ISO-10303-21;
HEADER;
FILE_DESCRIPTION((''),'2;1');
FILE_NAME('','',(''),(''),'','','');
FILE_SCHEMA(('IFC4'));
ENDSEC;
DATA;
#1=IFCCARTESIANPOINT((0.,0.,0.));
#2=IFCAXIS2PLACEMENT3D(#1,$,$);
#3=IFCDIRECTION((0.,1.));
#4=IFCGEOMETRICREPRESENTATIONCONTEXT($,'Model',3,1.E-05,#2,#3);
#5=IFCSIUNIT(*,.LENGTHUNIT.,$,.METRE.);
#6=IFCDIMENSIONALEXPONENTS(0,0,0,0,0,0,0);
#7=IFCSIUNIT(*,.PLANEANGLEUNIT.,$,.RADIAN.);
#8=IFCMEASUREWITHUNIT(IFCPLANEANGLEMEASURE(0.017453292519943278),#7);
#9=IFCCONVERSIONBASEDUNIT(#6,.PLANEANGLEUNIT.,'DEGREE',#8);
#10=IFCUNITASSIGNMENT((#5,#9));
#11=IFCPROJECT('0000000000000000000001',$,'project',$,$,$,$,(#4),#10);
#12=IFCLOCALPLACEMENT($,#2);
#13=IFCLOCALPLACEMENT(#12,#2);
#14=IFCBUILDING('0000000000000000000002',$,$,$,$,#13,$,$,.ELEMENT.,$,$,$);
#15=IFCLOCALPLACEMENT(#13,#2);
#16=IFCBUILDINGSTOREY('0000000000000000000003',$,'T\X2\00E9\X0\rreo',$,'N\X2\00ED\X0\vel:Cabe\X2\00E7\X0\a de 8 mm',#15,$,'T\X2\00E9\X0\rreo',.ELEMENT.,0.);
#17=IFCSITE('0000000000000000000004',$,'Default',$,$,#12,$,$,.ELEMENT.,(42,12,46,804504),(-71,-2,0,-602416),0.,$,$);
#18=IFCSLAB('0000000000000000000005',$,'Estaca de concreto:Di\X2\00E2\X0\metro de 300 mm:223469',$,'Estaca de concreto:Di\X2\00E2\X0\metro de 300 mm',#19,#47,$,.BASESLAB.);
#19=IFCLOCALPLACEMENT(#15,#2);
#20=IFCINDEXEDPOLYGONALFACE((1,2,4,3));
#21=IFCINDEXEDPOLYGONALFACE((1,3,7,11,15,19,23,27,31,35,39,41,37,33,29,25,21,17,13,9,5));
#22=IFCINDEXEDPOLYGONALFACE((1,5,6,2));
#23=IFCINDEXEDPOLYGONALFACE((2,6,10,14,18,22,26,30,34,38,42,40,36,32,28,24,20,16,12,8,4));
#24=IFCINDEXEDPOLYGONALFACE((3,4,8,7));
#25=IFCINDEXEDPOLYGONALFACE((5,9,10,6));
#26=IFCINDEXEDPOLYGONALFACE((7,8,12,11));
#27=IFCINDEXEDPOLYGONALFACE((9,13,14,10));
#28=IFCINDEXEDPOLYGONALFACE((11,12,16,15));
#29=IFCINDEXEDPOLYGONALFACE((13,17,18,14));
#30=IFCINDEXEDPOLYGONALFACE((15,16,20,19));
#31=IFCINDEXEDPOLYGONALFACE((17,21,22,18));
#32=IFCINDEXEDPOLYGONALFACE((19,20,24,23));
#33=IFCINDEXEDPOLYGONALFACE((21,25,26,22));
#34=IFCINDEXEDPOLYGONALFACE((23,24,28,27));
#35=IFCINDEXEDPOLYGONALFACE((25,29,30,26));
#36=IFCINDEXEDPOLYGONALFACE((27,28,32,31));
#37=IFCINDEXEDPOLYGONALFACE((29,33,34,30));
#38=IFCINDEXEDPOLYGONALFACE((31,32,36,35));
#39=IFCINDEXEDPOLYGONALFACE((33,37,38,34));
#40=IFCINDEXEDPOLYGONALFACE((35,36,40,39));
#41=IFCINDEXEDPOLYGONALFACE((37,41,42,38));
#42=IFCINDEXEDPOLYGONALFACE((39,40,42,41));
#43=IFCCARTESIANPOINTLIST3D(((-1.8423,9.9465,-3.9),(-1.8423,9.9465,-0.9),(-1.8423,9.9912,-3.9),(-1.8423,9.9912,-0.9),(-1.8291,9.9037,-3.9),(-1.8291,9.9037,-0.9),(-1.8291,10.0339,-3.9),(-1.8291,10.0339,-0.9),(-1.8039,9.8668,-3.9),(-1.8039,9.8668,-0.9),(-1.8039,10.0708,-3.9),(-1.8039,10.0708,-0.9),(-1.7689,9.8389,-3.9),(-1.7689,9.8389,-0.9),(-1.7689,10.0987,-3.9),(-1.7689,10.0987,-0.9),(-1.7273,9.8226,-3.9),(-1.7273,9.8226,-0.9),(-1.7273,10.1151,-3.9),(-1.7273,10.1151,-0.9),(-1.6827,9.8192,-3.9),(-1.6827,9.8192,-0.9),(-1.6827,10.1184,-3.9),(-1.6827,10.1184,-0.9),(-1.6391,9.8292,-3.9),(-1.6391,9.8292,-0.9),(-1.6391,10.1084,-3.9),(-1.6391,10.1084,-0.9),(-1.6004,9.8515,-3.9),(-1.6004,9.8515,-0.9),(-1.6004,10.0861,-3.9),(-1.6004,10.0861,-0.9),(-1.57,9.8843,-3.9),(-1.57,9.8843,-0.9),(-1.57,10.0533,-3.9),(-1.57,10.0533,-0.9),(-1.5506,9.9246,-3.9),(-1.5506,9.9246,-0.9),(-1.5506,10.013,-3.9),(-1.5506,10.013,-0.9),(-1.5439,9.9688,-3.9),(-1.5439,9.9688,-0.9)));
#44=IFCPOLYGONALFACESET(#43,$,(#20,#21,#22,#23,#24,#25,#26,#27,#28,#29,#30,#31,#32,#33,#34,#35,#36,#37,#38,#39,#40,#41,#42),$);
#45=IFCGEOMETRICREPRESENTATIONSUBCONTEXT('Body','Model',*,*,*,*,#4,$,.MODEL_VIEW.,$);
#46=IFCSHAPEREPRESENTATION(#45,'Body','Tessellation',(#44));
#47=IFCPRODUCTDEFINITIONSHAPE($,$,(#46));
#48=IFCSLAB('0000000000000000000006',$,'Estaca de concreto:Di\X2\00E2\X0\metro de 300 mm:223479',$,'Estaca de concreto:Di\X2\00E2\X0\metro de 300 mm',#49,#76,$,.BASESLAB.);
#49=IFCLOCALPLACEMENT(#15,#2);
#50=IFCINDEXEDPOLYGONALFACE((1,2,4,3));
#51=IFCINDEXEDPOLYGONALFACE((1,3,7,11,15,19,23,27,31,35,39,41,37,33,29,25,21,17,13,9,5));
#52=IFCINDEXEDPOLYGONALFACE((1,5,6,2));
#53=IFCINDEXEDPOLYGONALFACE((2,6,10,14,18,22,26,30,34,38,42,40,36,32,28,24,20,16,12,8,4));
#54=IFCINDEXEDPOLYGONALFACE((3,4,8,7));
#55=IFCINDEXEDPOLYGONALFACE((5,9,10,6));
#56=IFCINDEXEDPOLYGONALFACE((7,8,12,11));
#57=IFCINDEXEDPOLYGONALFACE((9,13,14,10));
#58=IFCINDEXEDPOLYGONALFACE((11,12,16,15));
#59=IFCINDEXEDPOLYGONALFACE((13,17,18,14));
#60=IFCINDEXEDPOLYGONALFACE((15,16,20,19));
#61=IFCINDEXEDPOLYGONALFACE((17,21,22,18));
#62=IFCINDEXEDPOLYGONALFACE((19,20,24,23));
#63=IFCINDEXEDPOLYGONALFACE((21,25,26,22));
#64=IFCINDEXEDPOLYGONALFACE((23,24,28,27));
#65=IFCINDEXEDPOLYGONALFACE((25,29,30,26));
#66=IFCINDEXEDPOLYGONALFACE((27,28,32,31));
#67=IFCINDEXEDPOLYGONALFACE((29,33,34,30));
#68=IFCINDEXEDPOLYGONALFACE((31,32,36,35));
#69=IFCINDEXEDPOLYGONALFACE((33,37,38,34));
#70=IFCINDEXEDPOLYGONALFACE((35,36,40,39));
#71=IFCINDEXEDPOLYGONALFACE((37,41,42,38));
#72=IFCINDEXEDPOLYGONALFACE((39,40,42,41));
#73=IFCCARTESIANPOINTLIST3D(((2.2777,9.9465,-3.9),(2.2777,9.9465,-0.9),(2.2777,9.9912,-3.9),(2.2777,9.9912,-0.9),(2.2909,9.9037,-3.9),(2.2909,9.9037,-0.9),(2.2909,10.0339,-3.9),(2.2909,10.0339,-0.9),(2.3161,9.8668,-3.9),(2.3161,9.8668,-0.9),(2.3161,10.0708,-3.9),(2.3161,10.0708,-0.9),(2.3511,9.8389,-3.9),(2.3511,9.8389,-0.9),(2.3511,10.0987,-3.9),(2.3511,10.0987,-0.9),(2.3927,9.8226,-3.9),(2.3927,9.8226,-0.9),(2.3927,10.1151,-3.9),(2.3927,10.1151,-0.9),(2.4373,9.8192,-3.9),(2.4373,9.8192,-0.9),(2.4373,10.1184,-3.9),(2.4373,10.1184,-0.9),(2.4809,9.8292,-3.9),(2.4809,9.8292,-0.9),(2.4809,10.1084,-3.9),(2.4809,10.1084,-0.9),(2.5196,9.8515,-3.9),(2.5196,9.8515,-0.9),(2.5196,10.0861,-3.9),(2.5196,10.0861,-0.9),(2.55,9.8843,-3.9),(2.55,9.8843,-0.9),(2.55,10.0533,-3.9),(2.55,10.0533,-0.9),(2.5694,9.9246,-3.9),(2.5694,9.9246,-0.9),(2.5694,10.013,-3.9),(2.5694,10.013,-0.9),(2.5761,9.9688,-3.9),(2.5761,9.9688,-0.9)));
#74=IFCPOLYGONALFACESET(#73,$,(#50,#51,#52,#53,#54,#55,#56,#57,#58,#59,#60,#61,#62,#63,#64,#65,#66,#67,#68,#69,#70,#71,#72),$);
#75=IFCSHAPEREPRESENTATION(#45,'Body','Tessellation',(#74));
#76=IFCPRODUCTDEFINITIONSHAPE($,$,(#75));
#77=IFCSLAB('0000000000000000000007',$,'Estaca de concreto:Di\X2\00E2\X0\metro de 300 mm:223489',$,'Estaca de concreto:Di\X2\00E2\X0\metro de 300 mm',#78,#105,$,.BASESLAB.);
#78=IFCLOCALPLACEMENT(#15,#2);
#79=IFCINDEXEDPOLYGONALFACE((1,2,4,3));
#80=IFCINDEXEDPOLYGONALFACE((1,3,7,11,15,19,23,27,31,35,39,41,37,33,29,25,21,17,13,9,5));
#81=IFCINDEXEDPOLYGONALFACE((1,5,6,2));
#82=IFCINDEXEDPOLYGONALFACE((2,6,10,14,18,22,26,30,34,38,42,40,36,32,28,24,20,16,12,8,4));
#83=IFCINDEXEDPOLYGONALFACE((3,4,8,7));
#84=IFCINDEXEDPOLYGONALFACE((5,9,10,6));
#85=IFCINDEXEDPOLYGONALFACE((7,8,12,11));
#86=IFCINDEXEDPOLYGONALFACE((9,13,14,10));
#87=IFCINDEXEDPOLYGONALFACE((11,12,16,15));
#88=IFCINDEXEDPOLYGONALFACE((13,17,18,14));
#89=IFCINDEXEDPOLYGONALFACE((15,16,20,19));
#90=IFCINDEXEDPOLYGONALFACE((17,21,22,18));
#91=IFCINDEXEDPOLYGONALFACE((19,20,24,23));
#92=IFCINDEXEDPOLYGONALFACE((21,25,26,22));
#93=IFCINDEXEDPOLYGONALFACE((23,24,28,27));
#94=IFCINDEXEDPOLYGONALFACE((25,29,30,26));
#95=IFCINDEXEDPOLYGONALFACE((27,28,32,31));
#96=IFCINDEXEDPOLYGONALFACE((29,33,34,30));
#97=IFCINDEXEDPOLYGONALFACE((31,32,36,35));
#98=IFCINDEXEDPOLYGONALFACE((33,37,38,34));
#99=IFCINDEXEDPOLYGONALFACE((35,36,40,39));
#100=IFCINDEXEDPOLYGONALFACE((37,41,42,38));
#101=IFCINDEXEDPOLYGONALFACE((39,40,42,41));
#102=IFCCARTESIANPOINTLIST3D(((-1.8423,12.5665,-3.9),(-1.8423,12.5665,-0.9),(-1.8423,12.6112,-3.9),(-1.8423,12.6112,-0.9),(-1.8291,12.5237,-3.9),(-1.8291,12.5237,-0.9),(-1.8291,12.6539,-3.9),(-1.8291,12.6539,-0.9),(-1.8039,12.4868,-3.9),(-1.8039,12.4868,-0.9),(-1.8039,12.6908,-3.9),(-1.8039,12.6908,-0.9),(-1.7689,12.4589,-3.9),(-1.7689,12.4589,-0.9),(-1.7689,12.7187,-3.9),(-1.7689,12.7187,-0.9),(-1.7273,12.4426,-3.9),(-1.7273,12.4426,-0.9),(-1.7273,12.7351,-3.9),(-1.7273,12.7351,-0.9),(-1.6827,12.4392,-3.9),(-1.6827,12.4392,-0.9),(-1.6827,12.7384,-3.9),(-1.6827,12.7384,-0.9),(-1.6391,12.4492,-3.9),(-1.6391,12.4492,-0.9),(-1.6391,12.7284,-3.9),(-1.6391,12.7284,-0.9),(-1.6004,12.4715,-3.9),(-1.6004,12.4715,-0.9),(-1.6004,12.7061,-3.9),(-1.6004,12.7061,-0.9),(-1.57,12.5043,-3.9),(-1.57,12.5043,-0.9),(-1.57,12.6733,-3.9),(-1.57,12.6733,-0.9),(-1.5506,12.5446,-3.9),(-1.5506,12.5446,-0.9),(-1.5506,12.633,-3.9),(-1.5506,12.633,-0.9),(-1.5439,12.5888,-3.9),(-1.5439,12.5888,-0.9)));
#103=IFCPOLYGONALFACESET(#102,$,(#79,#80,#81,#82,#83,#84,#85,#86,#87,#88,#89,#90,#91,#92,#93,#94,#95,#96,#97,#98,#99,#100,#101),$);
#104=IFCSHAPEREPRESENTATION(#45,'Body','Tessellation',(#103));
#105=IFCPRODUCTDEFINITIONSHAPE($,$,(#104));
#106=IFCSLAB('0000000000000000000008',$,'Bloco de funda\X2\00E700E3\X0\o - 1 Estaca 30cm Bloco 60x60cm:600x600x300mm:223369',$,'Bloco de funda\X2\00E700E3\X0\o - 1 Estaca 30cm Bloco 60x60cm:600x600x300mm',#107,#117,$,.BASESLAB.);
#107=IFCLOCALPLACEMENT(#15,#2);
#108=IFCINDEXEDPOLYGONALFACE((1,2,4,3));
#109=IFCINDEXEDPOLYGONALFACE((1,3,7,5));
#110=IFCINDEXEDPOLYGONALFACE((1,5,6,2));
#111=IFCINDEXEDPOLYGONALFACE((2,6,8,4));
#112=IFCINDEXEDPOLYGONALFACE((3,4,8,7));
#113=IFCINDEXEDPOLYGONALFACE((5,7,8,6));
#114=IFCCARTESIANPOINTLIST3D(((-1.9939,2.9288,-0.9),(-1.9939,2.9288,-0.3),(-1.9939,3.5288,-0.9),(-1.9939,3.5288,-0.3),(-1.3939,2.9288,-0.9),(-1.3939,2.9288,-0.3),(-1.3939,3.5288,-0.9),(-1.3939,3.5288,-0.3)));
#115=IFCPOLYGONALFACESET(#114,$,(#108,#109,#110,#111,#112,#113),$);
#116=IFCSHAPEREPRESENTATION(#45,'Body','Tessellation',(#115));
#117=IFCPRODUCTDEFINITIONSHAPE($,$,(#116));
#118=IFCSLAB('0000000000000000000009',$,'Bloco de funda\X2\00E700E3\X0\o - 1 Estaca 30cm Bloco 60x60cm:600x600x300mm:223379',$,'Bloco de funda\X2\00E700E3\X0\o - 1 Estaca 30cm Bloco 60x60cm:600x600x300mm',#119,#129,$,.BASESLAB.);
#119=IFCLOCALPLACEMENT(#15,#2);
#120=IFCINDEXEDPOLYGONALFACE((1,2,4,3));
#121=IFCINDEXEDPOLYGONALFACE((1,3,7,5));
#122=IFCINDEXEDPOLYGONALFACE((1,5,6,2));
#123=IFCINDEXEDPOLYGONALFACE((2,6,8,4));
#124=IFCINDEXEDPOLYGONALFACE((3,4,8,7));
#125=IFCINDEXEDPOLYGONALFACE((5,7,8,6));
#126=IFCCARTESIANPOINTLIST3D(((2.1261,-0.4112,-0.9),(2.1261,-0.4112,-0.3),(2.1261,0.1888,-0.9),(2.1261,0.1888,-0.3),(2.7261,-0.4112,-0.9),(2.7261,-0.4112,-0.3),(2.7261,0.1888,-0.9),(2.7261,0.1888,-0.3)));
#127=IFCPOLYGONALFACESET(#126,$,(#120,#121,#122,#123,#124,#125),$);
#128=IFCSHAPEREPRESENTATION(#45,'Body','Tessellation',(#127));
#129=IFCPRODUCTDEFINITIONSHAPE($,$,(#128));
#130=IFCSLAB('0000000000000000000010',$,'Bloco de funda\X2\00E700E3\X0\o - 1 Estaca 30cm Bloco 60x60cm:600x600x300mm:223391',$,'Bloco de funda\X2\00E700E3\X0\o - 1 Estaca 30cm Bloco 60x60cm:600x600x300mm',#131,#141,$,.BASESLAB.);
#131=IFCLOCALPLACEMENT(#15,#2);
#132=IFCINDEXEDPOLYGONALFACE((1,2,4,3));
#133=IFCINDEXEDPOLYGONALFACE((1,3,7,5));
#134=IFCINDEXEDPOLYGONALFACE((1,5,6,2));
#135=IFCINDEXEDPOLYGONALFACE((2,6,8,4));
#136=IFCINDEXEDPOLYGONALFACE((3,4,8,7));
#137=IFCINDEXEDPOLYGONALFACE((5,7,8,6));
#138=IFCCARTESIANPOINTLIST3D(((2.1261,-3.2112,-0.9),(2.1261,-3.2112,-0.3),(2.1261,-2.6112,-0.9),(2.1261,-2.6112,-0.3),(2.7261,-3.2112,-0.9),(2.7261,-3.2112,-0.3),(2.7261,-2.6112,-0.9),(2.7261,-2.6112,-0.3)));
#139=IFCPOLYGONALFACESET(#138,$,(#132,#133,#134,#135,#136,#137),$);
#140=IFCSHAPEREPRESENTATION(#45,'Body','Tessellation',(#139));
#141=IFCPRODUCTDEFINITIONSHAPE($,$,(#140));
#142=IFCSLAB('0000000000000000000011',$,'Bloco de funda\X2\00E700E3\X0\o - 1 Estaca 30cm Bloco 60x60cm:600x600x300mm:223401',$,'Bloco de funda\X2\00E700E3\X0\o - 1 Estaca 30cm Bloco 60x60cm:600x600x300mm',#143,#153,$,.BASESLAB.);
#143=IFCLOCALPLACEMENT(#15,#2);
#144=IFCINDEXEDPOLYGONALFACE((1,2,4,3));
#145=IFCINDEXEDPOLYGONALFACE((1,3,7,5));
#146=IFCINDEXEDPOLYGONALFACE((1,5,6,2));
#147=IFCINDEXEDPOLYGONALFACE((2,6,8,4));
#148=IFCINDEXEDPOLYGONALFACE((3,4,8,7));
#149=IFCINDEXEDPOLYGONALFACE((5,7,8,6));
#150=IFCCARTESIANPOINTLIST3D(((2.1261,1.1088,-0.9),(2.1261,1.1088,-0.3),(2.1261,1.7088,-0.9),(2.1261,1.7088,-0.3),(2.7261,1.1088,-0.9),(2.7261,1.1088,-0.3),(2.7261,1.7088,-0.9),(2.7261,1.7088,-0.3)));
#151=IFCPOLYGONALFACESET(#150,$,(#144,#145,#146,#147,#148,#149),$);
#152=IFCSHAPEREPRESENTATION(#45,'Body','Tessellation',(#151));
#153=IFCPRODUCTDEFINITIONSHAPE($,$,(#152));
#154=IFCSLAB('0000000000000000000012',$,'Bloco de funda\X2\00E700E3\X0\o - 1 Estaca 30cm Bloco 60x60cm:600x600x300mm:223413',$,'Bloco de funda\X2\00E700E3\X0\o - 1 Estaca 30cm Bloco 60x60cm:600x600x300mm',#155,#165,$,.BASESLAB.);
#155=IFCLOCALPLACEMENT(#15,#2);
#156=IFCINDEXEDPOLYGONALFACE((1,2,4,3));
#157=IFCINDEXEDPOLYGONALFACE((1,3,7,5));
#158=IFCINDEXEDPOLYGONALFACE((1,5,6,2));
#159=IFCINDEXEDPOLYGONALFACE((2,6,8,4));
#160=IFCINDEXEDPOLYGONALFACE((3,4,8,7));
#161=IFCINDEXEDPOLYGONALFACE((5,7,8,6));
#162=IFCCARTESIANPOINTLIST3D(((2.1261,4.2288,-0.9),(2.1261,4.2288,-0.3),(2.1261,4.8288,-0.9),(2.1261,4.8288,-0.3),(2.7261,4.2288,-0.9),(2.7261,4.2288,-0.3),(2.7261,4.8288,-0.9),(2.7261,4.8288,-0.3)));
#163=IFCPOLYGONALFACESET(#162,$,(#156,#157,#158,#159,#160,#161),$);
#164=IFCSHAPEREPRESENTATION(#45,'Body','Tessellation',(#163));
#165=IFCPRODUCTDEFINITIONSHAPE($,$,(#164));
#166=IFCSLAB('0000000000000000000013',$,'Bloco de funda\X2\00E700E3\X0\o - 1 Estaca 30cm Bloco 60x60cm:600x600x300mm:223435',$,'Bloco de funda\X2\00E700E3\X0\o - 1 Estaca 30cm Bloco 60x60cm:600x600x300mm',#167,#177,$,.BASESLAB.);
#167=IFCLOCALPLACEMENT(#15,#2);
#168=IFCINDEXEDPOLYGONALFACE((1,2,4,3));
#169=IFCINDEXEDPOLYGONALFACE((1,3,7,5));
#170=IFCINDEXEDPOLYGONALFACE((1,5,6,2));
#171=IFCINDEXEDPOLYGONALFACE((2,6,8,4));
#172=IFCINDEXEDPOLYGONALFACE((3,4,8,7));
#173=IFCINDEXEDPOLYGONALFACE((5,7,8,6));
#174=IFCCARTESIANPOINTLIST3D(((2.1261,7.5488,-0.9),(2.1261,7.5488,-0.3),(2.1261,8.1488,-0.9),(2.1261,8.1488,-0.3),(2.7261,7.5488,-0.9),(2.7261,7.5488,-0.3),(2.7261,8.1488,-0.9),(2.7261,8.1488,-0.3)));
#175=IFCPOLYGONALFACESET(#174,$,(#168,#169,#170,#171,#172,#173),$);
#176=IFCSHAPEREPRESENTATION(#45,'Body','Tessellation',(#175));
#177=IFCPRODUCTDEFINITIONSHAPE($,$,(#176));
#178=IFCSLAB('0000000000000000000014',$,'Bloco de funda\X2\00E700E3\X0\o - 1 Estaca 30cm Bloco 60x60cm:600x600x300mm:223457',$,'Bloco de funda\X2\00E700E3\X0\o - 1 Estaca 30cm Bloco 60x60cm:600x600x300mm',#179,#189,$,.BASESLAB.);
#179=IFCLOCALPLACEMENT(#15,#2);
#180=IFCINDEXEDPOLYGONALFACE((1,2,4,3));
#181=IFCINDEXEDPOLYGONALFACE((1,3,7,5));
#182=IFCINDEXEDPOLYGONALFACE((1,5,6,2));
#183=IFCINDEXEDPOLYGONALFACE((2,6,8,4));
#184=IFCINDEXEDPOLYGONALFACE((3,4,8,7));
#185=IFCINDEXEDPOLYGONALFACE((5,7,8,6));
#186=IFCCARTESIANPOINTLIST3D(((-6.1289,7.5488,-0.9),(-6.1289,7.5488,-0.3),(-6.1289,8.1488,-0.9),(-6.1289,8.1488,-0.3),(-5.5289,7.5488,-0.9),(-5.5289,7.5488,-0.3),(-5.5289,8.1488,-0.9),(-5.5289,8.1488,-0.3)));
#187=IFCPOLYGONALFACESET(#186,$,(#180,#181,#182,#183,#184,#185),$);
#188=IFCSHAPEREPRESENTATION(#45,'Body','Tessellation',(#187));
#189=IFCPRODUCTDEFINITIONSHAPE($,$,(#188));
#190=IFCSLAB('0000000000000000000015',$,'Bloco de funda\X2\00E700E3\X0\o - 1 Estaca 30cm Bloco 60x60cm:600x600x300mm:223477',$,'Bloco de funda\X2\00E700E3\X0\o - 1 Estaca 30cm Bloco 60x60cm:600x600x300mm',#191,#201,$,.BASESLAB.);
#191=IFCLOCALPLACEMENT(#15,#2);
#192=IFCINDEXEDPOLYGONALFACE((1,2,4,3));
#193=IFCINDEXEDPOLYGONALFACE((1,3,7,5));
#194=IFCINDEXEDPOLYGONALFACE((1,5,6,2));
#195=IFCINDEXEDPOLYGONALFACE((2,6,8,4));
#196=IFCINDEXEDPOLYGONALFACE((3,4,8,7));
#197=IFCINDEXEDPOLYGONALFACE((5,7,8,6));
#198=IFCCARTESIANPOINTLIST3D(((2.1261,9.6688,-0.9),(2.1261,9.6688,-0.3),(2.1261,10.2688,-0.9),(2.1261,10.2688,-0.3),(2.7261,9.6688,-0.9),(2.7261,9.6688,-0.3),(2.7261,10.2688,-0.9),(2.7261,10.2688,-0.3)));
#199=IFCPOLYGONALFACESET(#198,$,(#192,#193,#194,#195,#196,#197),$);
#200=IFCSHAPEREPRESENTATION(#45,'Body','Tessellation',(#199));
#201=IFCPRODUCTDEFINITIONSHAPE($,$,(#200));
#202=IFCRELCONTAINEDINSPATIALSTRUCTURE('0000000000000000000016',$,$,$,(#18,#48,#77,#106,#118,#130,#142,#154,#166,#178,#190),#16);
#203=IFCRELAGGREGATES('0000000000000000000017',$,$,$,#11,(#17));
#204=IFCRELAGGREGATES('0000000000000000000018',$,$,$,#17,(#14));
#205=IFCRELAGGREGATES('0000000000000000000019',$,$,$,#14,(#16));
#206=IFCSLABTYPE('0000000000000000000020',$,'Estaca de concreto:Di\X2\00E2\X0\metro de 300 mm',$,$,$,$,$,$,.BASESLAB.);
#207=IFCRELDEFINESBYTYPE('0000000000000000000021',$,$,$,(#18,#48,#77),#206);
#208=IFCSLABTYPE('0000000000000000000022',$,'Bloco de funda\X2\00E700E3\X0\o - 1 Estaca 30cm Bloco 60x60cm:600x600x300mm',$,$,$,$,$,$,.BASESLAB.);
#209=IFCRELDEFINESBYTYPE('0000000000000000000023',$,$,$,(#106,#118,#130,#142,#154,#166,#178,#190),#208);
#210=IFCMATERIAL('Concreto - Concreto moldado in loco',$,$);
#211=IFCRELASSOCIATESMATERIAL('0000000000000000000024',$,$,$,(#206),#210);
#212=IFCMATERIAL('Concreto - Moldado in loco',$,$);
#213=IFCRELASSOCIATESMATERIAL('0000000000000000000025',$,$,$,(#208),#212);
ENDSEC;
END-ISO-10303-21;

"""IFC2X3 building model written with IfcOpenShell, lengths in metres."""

from ifc_helpers import new_model, entity, si_unit, converted_unit, direction, frame, frame_2d, origin, origin_2d_with_axis, place, context, subcontext, project, spatial, rectangle, circle, extrude, material, type_object, element, save


model = new_model("IFC2X3")

# Units and contexts
model_context = context("Model", 3, precision=1e-05, world=origin(), true_north=direction((0.0, 1.0)))
body_context = subcontext(model_context, "Body", "Model", "MODEL_VIEW")
ifc_project = project(units=[si_unit("LENGTHUNIT", "METRE"), converted_unit("PLANEANGLEUNIT", "DEGREE", entity("IfcPlaneAngleMeasure", 0.017453292519943278), si_unit("PLANEANGLEUNIT", "RADIAN"), dimensions=[0, 0, 0, 0, 0, 0, 0])], contexts=[model_context])

# Site, building, storey
site_placement = place(None, origin())
site = spatial("IfcSite", under=ifc_project, at=site_placement, Name="Default", CompositionType="ELEMENT", RefLatitude=(42, 12, 46, 804504), RefLongitude=(-71, -2, 0, -602416), RefElevation=0.0)
building_placement = place(site_placement, origin())
building = spatial("IfcBuilding", under=site, at=building_placement, CompositionType="ELEMENT")
storey_placement = place(building_placement, origin())
storey = spatial("IfcBuildingStorey", under=building, at=storey_placement, Name="Térreo", ObjectType="Nível:Cabeça de 8 mm", LongName="Térreo", CompositionType="ELEMENT", Elevation=0.0)

# Slabs
ifc_material_1 = material(Name="Concreto - Moldado in loco")
ifc_material_2 = material(Name="Concreto - Concreto moldado in loco")
slab_type_1 = type_object("IfcSlabType", Name="Estaca de concreto:Diâmetro de 300 mm", PredefinedType="BASESLAB", material=ifc_material_2)
slab_1_placement = place(storey_placement, origin())
element("IfcSlab", 1, at=slab_1_placement, inside=storey, type_object=slab_type_1, Name="Estaca de concreto:Diâmetro de 300 mm:223469", ObjectType="Estaca de concreto:Diâmetro de 300 mm", PredefinedType="BASESLAB", context=body_context, shape_type="SweptSolid", body=[
    extrude(circle(Radius=0.15, at=origin_2d_with_axis()), frame((-1.6939, 9.9688, -3.9)), (0.0, 0.0, 1.0), 3.0),
])
slab_2_placement = place(storey_placement, origin())
element("IfcSlab", 2, at=slab_2_placement, inside=storey, type_object=slab_type_1, Name="Estaca de concreto:Diâmetro de 300 mm:223479", ObjectType="Estaca de concreto:Diâmetro de 300 mm", PredefinedType="BASESLAB", context=body_context, shape_type="SweptSolid", body=[
    extrude(circle(Radius=0.15, at=frame_2d((0.0, 0.0), x_axis=(1.0, 0.0))), frame((2.4261, 9.9688, -3.9)), (0.0, 0.0, 1.0), 3.0),
])
slab_3_placement = place(storey_placement, origin())
element("IfcSlab", 3, at=slab_3_placement, inside=storey, type_object=slab_type_1, Name="Estaca de concreto:Diâmetro de 300 mm:223489", ObjectType="Estaca de concreto:Diâmetro de 300 mm", PredefinedType="BASESLAB", context=body_context, shape_type="SweptSolid", body=[
    extrude(circle(Radius=0.15, at=origin_2d_with_axis()), frame((-1.6939, 12.5888, -3.9)), (0.0, 0.0, 1.0), 3.0),
])
slab_type_2 = type_object("IfcSlabType", Name="Bloco de fundação - 1 Estaca 30cm Bloco 60x60cm:600x600x300mm", PredefinedType="BASESLAB", material=ifc_material_1)
slab_4_placement = place(storey_placement, origin())
element("IfcSlab", 4, at=slab_4_placement, inside=storey, type_object=slab_type_2, Name="Bloco de fundação - 1 Estaca 30cm Bloco 60x60cm:600x600x300mm:223369", ObjectType="Bloco de fundação - 1 Estaca 30cm Bloco 60x60cm:600x600x300mm", PredefinedType="BASESLAB", context=body_context, shape_type="SweptSolid", body=[
    extrude(rectangle(XDim=0.6, YDim=0.6, at=frame_2d((0.0, 0.0), x_axis=(1.0, 0.0))), frame((-1.6939, 3.2288, -0.9), z_axis=(0.0, 0.0, 1.0), x_axis=(-1.0, 0.0, 0.0)), (0.0, 0.0, 1.0), 0.6),
])
slab_5_placement = place(storey_placement, origin())
element("IfcSlab", 5, at=slab_5_placement, inside=storey, type_object=slab_type_2, Name="Bloco de fundação - 1 Estaca 30cm Bloco 60x60cm:600x600x300mm:223379", ObjectType="Bloco de fundação - 1 Estaca 30cm Bloco 60x60cm:600x600x300mm", PredefinedType="BASESLAB", context=body_context, shape_type="SweptSolid", body=[
    extrude(rectangle(XDim=0.6, YDim=0.6, at=origin_2d_with_axis()), frame((2.4261, -0.1112, -0.9), z_axis=(0.0, 0.0, 1.0), x_axis=(-1.0, 0.0, 0.0)), (0.0, 0.0, 1.0), 0.6),
])
slab_6_placement = place(storey_placement, origin())
element("IfcSlab", 6, at=slab_6_placement, inside=storey, type_object=slab_type_2, Name="Bloco de fundação - 1 Estaca 30cm Bloco 60x60cm:600x600x300mm:223391", ObjectType="Bloco de fundação - 1 Estaca 30cm Bloco 60x60cm:600x600x300mm", PredefinedType="BASESLAB", context=body_context, shape_type="SweptSolid", body=[
    extrude(rectangle(XDim=0.6, YDim=0.6, at=origin_2d_with_axis()), frame((2.4261, -2.9112, -0.9), z_axis=(0.0, 0.0, 1.0), x_axis=(-1.0, 0.0, 0.0)), (0.0, 0.0, 1.0), 0.6),
])
slab_7_placement = place(storey_placement, origin())
element("IfcSlab", 7, at=slab_7_placement, inside=storey, type_object=slab_type_2, Name="Bloco de fundação - 1 Estaca 30cm Bloco 60x60cm:600x600x300mm:223401", ObjectType="Bloco de fundação - 1 Estaca 30cm Bloco 60x60cm:600x600x300mm", PredefinedType="BASESLAB", context=body_context, shape_type="SweptSolid", body=[
    extrude(rectangle(XDim=0.6, YDim=0.6, at=frame_2d((0.0, 0.0), x_axis=(1.0, 0.0))), frame((2.4261, 1.4088, -0.9), z_axis=(0.0, 0.0, 1.0), x_axis=(-1.0, 0.0, 0.0)), (0.0, 0.0, 1.0), 0.6),
])
slab_8_placement = place(storey_placement, origin())
element("IfcSlab", 8, at=slab_8_placement, inside=storey, type_object=slab_type_2, Name="Bloco de fundação - 1 Estaca 30cm Bloco 60x60cm:600x600x300mm:223413", ObjectType="Bloco de fundação - 1 Estaca 30cm Bloco 60x60cm:600x600x300mm", PredefinedType="BASESLAB", context=body_context, shape_type="SweptSolid", body=[
    extrude(rectangle(XDim=0.6, YDim=0.6, at=origin_2d_with_axis()), frame((2.4261, 4.5288, -0.9), z_axis=(0.0, 0.0, 1.0), x_axis=(-1.0, 0.0, 0.0)), (0.0, 0.0, 1.0), 0.6),
])
slab_9_placement = place(storey_placement, origin())
element("IfcSlab", 9, at=slab_9_placement, inside=storey, type_object=slab_type_2, Name="Bloco de fundação - 1 Estaca 30cm Bloco 60x60cm:600x600x300mm:223435", ObjectType="Bloco de fundação - 1 Estaca 30cm Bloco 60x60cm:600x600x300mm", PredefinedType="BASESLAB", context=body_context, shape_type="SweptSolid", body=[
    extrude(rectangle(XDim=0.6, YDim=0.6, at=origin_2d_with_axis()), frame((2.4261, 7.8488, -0.9), z_axis=(0.0, 0.0, 1.0), x_axis=(-1.0, 0.0, 0.0)), (0.0, 0.0, 1.0), 0.6),
])
slab_10_placement = place(storey_placement, origin())
element("IfcSlab", 10, at=slab_10_placement, inside=storey, type_object=slab_type_2, Name="Bloco de fundação - 1 Estaca 30cm Bloco 60x60cm:600x600x300mm:223457", ObjectType="Bloco de fundação - 1 Estaca 30cm Bloco 60x60cm:600x600x300mm", PredefinedType="BASESLAB", context=body_context, shape_type="SweptSolid", body=[
    extrude(rectangle(XDim=0.6, YDim=0.6, at=origin_2d_with_axis()), frame((-5.8289, 7.8488, -0.9), z_axis=(0.0, 0.0, 1.0), x_axis=(-1.0, 0.0, 0.0)), (0.0, 0.0, 1.0), 0.6),
])
slab_11_placement = place(storey_placement, origin())
element("IfcSlab", 11, at=slab_11_placement, inside=storey, type_object=slab_type_2, Name="Bloco de fundação - 1 Estaca 30cm Bloco 60x60cm:600x600x300mm:223477", ObjectType="Bloco de fundação - 1 Estaca 30cm Bloco 60x60cm:600x600x300mm", PredefinedType="BASESLAB", context=body_context, shape_type="SweptSolid", body=[
    extrude(rectangle(XDim=0.6, YDim=0.6, at=frame_2d((0.0, 0.0), x_axis=(1.0, 0.0))), frame((2.4261, 9.9688, -0.9), z_axis=(0.0, 0.0, 1.0), x_axis=(-1.0, 0.0, 0.0)), (0.0, 0.0, 1.0), 0.6),
])

save(model, "model.ifc")
